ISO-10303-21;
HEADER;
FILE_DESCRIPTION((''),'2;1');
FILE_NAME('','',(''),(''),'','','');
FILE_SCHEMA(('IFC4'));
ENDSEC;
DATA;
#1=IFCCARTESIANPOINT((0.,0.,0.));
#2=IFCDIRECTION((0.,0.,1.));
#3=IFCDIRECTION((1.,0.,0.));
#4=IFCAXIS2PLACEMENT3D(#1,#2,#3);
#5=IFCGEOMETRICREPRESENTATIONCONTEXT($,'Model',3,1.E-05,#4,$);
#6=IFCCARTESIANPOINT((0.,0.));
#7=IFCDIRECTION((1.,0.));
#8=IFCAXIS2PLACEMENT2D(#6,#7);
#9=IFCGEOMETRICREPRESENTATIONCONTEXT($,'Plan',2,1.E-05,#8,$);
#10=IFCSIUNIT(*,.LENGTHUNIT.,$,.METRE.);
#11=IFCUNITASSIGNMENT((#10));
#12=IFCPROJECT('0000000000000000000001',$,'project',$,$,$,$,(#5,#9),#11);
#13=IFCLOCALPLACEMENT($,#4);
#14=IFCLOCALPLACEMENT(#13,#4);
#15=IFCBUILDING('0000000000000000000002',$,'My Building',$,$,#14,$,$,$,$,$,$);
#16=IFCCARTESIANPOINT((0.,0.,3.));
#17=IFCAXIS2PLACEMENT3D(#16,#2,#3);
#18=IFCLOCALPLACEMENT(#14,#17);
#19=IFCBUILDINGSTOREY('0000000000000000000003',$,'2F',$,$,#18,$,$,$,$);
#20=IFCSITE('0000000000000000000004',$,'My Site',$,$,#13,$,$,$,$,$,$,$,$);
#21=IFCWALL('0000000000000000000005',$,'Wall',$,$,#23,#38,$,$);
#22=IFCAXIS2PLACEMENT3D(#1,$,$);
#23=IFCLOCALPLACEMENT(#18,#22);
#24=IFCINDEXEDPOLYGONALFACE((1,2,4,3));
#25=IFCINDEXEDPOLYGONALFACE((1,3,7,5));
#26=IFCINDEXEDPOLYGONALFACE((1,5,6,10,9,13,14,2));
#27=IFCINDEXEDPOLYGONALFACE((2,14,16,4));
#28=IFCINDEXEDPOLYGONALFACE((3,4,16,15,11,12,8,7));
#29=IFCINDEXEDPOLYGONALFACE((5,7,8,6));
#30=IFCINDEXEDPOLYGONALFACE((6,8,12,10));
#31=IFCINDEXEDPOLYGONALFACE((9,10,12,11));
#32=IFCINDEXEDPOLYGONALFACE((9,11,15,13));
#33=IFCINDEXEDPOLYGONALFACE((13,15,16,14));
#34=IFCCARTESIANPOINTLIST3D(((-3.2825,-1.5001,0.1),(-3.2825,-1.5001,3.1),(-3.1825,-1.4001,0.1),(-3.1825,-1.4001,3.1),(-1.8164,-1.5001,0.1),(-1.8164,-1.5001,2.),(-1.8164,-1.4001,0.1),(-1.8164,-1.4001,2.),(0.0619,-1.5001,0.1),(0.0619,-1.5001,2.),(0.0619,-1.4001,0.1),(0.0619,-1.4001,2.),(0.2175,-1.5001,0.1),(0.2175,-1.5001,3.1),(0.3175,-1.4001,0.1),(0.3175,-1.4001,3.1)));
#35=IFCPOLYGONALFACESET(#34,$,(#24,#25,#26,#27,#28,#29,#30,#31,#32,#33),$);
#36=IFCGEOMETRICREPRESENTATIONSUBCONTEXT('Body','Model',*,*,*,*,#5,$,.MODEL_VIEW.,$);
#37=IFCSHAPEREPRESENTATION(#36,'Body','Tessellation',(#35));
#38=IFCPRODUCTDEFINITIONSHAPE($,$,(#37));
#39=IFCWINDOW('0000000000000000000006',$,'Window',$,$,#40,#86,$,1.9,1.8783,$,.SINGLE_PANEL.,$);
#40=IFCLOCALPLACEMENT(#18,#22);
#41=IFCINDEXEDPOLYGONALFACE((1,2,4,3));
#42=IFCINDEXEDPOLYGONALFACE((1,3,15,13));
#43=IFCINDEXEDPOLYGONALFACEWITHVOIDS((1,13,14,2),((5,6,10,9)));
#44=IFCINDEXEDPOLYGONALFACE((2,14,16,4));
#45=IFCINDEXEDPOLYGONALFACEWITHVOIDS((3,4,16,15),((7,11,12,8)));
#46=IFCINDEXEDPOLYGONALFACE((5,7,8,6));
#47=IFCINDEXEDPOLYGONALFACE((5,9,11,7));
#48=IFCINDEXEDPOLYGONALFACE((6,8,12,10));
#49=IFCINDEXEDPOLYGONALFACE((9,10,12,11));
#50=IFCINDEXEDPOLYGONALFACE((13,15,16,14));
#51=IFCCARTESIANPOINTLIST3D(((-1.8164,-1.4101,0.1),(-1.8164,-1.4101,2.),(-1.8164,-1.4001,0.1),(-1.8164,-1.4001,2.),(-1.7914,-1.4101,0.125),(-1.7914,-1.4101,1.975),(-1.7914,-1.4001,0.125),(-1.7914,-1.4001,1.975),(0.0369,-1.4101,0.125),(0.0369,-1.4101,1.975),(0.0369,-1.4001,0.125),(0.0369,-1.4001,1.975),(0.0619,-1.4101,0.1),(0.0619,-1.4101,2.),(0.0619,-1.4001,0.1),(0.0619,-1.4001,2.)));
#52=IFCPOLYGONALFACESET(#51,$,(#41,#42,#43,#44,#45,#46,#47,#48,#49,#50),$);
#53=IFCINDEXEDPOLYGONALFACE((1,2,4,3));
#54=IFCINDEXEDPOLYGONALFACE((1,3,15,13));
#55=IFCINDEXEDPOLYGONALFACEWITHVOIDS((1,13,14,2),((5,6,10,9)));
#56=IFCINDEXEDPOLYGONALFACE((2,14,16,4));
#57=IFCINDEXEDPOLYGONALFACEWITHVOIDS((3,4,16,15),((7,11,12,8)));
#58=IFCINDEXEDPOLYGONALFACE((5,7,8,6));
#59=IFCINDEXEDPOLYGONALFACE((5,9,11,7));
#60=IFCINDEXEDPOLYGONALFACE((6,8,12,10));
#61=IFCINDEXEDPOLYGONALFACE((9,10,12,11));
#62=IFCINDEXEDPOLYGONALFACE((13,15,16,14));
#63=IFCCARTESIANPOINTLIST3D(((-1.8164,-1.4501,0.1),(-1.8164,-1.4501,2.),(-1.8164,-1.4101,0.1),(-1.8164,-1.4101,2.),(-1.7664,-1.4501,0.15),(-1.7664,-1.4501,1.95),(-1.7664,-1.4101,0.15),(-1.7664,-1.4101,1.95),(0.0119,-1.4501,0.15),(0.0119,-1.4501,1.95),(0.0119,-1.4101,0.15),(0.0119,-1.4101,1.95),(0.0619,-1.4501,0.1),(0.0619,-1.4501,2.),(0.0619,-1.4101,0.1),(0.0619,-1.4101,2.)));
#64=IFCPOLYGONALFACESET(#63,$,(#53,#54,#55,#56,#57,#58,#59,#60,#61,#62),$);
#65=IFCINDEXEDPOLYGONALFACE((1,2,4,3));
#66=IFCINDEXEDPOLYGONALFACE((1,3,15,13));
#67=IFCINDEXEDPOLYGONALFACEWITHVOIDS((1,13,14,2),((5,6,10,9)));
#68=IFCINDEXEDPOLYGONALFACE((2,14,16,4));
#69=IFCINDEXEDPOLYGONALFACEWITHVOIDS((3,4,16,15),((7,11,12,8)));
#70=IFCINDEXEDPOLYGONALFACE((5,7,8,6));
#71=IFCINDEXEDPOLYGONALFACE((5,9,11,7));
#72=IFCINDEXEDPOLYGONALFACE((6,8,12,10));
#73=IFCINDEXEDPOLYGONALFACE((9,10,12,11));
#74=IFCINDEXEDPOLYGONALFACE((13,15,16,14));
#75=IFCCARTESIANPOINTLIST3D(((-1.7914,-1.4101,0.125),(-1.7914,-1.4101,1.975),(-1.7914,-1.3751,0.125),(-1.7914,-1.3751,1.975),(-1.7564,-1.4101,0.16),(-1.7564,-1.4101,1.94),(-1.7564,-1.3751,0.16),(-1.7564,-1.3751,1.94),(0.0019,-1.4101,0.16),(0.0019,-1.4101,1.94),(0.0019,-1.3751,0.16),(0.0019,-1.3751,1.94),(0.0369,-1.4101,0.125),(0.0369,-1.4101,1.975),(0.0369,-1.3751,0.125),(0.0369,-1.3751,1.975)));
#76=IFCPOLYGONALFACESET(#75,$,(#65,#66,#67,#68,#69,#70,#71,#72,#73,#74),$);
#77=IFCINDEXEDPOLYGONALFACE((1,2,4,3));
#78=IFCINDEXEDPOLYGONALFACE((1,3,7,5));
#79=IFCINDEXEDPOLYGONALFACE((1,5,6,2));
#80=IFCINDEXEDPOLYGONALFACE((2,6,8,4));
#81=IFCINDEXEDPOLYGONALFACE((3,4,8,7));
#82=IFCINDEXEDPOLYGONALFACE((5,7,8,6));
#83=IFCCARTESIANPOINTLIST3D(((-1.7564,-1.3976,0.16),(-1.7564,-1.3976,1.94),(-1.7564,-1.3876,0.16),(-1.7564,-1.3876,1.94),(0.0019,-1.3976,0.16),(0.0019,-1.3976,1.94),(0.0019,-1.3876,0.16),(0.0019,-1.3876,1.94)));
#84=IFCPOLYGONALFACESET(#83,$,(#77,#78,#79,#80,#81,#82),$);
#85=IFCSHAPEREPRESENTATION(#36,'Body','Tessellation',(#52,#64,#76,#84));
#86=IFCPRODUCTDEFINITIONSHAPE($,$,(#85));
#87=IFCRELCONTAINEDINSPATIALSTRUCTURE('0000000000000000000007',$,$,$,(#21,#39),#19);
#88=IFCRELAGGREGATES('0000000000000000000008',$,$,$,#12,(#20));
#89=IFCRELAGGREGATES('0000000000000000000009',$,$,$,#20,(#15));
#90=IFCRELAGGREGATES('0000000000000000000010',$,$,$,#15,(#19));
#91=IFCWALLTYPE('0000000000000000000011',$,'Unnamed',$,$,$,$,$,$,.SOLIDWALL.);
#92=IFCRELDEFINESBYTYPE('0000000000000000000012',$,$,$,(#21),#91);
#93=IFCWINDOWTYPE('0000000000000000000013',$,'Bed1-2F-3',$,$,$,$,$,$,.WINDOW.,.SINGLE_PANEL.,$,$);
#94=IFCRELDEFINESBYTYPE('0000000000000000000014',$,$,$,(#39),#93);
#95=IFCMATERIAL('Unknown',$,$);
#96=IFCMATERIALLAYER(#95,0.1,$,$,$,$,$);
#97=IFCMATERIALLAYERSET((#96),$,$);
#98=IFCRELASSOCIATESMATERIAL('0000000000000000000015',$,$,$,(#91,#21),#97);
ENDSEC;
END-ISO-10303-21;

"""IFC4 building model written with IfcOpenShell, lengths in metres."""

from ifc_helpers import new_model, entity, si_unit, frame, origin_with_axes, origin_2d_with_axis, place, context, subcontext, project, spatial, line, indexed_curve, outline, extrude, shape, source, transform, mapped, material, layer, layer_set, layer_usage, type_object, type_shapes, element, fill, save


model = new_model("IFC4")

# Units and contexts
model_context = context("Model", 3, precision=1e-05, world=origin_with_axes())
plan_context = context("Plan", 2, precision=1e-05, world=origin_2d_with_axis())
body_context_1 = subcontext(model_context, "Body", "Model", "MODEL_VIEW")
body_context_2 = subcontext(plan_context, "Body", "Plan", "PLAN_VIEW")
ifc_project = project(units=[si_unit("LENGTHUNIT", "METRE")], contexts=[model_context, plan_context])

# Site, building, storey
site_placement = place(None, origin_with_axes())
site = spatial("IfcSite", under=ifc_project, at=site_placement, Name="My Site")
building_placement = place(site_placement, origin_with_axes())
building = spatial("IfcBuilding", under=site, at=building_placement, Name="My Building")
storey_placement = place(building_placement, frame((0.0, 0.0, 3.0), z_axis=(0.0, 0.0, 1.0), x_axis=(1.0, 0.0, 0.0)))
storey = spatial("IfcBuildingStorey", under=building, at=storey_placement, Name="2F")

# Shared definitions
ifc_material = material(Name="Unknown")

# Shared definitions
ifc_layer_1 = layer(ifc_material, 0.1)
ifc_layer_set_1 = layer_set([ifc_layer_1])
wall_type = type_object("IfcWallType", Name="Unnamed", PredefinedType="SOLIDWALL", material=ifc_layer_set_1)

# Wall, opening, window
ifc_layer_usage_1 = layer_usage(ifc_layer_set_1, "AXIS2", "POSITIVE", 0.0)
wall_1_placement = place(storey_placement, frame((-3.1825, -1.5001, 0.1), z_axis=(0.0, 0.0, 1.0), x_axis=(1.0, 0.0, 0.0)))
wall_1 = element("IfcWall", 1, at=wall_1_placement, inside=storey, type_object=wall_type, material=ifc_layer_usage_1, Name="Wall", context=body_context_1, shape_type="SweptSolid", body=[
    extrude(outline(indexed_curve([(-0.1, 0.0), (0.0, 0.1), (3.5, 0.1), (3.4, 0.0)], segments=[line(1, 2, 3, 4, 1)])), origin_with_axes(), (0.0, 0.0, 1.0), 3.0),
])
shared_shape_1 = source(origin_with_axes(), body_context_1, "Body", "SweptSolid", [
    extrude(outline(indexed_curve([(0.0, 0.0), (1.8783, 0.0), (1.8783, 1.9), (0.0, 1.9)], segments=[line(1, 2, 3, 4, 1)])), frame((0.0, -0.6, 0.0), z_axis=(0.0, -1.0, 0.0), x_axis=(1.0, 0.0, 0.0)), (0.0, 0.0, -1.0), 1.2),
])
opening_1_placement = place(wall_1_placement, frame((1.3661, 0.0, 0.0), z_axis=(0.0, 0.0, 1.0), x_axis=(1.0, 0.0, 0.0)))
opening_1 = element("IfcOpeningElement", 2, at=opening_1_placement, cuts=wall_1, PredefinedType="OPENING", context=body_context_1, shape_type="MappedRepresentation", body=[
    mapped(shared_shape_1, transform((0.0, 0.0, 0.0), x_axis=(1.0, 0.0, 0.0), y_axis=(0.0, 1.0, 0.0), z_axis=(0.0, 0.0, 1.0), scale=1.0)),
])
window_type_1 = type_object("IfcWindowType", Name="Bed1-2F-3", PartitioningType="SINGLE_PANEL", PredefinedType="WINDOW")
shared_shape_2 = source(origin_with_axes(), body_context_1, "Body", "SweptSolid", [
    extrude(outline(indexed_curve([(0.0, 0.0), (1.8783, 0.0), (1.8783, 1.9), (0.0, 1.9)], segments=[line(1, 2, 3, 4, 1)]), holes=[indexed_curve([(0.025, 0.025), (1.8533, 0.025), (1.8533, 1.875), (0.025, 1.875)], segments=[line(1, 2, 3, 4, 1)])]), frame((0.0, 0.09, 0.0), z_axis=(0.0, -1.0, 0.0), x_axis=(1.0, 0.0, 0.0)), (0.0, 0.0, -1.0), 0.01),
    extrude(outline(indexed_curve([(0.0, 0.0), (1.8783, 0.0), (1.8783, 1.9), (0.0, 1.9)], segments=[line(1, 2, 3, 4, 1)]), holes=[indexed_curve([(0.05, 0.05), (1.8283, 0.05), (1.8283, 1.85), (0.05, 1.85)], segments=[line(1, 2, 3, 4, 1)])]), frame((0.0, 0.05, 0.0), z_axis=(0.0, -1.0, 0.0), x_axis=(1.0, 0.0, 0.0)), (0.0, 0.0, -1.0), 0.04),
    extrude(outline(indexed_curve([(0.0, 0.0), (1.8283, 0.0), (1.8283, 1.85), (0.0, 1.85)], segments=[line(1, 2, 3, 4, 1)]), holes=[indexed_curve([(0.035, 0.035), (1.7933, 0.035), (1.7933, 1.815), (0.035, 1.815)], segments=[line(1, 2, 3, 4, 1)])]), frame((0.025, 0.09, 0.025), z_axis=(0.0, -1.0, 0.0), x_axis=(1.0, 0.0, 0.0)), (0.0, 0.0, -1.0), 0.035),
    extrude(outline(indexed_curve([(0.035, 0.035), (1.7933, 0.035), (1.7933, 1.815), (0.035, 1.815)], segments=[line(1, 2, 3, 4, 1)])), frame((0.025, 0.1025, 0.025), z_axis=(0.0, -1.0, 0.0), x_axis=(1.0, 0.0, 0.0)), (0.0, 0.0, -1.0), 0.01),
])
shared_shape_3 = source(origin_with_axes(), body_context_2, "Body", "Curve2D", [
    entity("IfcIndexedPolyCurve", entity("IfcCartesianPointList2D", [[0.05, 0.05], [1.8283, 0.05]])),
    entity("IfcIndexedPolyCurve", entity("IfcCartesianPointList2D", [[0.0, 0.1], [0.025, 0.1], [0.025, 0.09], [0.05, 0.09], [0.05, 0.05], [0.0, 0.05]]), [entity("IfcLineIndex", [1, 2, 3, 4, 5, 6, 1])]),
    entity("IfcIndexedPolyCurve", entity("IfcCartesianPointList2D", [[1.8783, 0.1], [1.8533, 0.1], [1.8533, 0.09], [1.8283, 0.09], [1.8283, 0.05], [1.8783, 0.05]]), [entity("IfcLineIndex", [1, 2, 3, 4, 5, 6, 1])]),
    entity("IfcIndexedPolyCurve", entity("IfcCartesianPointList2D", [[0.025, 0.09], [0.06, 0.09], [0.06, 0.125], [0.025, 0.125]]), [entity("IfcLineIndex", [1, 2, 3, 4, 1])]),
    entity("IfcIndexedPolyCurve", entity("IfcCartesianPointList2D", [[1.8533, 0.09], [1.8183, 0.09], [1.8183, 0.125], [1.8533, 0.125]]), [entity("IfcLineIndex", [1, 2, 3, 4, 1])]),
    entity("IfcIndexedPolyCurve", entity("IfcCartesianPointList2D", [[0.06, 0.09], [1.8183, 0.09]])),
    entity("IfcIndexedPolyCurve", entity("IfcCartesianPointList2D", [[0.06, 0.125], [1.8183, 0.125]])),
    entity("IfcIndexedPolyCurve", entity("IfcCartesianPointList2D", [[0.06, 0.1075], [1.8183, 0.1075]])),
])
type_shapes(window_type_1, [shared_shape_2, shared_shape_3])
window_1_placement = place(opening_1_placement, frame((0.0, 0.0, 0.0), z_axis=(0.0, 0.0, 1.0), x_axis=(1.0, 0.0, 0.0)))
window_1 = element("IfcWindow", 3, at=window_1_placement, inside=storey, type_object=window_type_1, Name="Window", OverallHeight=1.9, OverallWidth=1.8783, PartitioningType="SINGLE_PANEL", shapes=[
    shape(body_context_1, "Body", "MappedRepresentation", [mapped(shared_shape_2, transform((0.0, 0.0, 0.0), x_axis=(1.0, 0.0, 0.0), y_axis=(0.0, 1.0, 0.0), z_axis=(0.0, 0.0, 1.0), scale=1.0))]),
    shape(body_context_2, "Body", "MappedRepresentation", [mapped(shared_shape_3, transform((0.0, 0.0, 0.0), x_axis=(1.0, 0.0, 0.0), y_axis=(0.0, 1.0, 0.0), z_axis=(0.0, 0.0, 1.0), scale=1.0))]),
])
fill(opening_1, window_1)

save(model, "model.ifc")
